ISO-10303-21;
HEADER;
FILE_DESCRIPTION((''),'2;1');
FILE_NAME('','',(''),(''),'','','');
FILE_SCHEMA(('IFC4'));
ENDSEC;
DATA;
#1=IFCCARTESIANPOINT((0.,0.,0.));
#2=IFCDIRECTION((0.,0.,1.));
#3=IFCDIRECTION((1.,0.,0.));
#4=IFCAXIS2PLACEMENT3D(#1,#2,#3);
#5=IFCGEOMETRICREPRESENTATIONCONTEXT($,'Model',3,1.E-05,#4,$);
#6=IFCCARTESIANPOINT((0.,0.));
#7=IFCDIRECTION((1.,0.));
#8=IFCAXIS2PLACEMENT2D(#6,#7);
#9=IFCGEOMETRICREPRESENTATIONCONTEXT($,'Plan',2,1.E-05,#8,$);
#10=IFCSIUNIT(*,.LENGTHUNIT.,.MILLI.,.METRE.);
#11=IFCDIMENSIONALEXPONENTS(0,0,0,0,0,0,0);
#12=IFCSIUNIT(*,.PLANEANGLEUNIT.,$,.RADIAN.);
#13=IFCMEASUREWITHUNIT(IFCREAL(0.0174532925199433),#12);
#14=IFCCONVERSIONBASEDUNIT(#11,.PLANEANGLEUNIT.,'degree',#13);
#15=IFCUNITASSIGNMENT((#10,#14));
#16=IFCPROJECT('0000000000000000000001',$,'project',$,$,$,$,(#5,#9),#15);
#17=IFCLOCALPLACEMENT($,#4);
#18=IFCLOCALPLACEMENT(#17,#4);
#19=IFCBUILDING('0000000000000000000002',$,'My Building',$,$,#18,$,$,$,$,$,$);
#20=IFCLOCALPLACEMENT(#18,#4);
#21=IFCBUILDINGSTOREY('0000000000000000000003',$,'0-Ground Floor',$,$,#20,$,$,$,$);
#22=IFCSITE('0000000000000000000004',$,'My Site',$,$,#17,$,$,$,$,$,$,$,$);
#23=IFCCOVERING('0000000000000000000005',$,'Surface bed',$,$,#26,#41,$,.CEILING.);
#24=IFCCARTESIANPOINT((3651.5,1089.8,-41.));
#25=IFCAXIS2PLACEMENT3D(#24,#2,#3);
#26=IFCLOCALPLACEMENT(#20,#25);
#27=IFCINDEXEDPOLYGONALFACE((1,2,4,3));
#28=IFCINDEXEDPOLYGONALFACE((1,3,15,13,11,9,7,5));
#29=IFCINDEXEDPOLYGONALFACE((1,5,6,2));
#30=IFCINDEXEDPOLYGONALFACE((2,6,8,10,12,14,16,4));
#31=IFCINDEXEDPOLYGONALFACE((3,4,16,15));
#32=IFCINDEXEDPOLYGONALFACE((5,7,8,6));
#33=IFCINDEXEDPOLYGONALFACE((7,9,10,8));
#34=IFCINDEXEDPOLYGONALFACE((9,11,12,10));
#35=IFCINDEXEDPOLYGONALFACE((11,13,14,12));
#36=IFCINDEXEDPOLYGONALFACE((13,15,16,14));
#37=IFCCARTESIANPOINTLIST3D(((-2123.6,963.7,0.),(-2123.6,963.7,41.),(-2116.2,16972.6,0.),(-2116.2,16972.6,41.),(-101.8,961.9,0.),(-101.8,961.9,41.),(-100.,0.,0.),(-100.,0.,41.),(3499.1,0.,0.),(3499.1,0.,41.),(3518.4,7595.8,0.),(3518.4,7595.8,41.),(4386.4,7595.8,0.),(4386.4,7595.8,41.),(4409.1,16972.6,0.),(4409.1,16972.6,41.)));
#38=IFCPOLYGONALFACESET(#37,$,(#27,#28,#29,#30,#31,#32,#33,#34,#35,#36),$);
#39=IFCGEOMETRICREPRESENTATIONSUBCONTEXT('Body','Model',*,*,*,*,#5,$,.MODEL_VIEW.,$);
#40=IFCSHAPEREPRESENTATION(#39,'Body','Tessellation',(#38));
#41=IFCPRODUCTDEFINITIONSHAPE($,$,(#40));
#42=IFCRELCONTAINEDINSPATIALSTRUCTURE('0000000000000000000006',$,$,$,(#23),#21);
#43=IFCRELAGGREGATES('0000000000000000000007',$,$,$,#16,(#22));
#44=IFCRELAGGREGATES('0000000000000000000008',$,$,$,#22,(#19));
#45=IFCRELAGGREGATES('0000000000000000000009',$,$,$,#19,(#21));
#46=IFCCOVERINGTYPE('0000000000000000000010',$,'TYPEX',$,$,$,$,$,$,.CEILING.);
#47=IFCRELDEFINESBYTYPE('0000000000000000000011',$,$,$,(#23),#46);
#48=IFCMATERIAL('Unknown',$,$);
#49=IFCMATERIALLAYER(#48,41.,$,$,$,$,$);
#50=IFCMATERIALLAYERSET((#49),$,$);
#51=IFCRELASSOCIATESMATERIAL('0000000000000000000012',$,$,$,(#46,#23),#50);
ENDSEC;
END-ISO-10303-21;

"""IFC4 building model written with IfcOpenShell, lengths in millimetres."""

from ifc_helpers import new_model, entity, si_unit, converted_unit, frame, origin_with_axes, origin_2d_with_axis, place, context, subcontext, project, spatial, line, indexed_curve, outline, extrude, material, layer, layer_set, layer_usage, type_object, element, save


model = new_model("IFC4")

# Units and contexts
model_context = context("Model", 3, precision=1e-05, world=origin_with_axes())
plan_context = context("Plan", 2, precision=1e-05, world=origin_2d_with_axis())
body_context_1 = subcontext(model_context, "Body", "Model", "MODEL_VIEW")
ifc_project = project(units=[si_unit("LENGTHUNIT", "METRE", prefix="MILLI"), converted_unit("PLANEANGLEUNIT", "degree", entity("IfcReal", 0.0174532925199433), si_unit("PLANEANGLEUNIT", "RADIAN"), dimensions=[0, 0, 0, 0, 0, 0, 0])], contexts=[model_context, plan_context])

# Site, building, storey
site_placement = place(None, origin_with_axes())
site = spatial("IfcSite", under=ifc_project, at=site_placement, Name="My Site")
building_placement = place(site_placement, origin_with_axes())
building = spatial("IfcBuilding", under=site, at=building_placement, Name="My Building")
storey_placement = place(building_placement, origin_with_axes())
storey = spatial("IfcBuildingStorey", under=building, at=storey_placement, Name="0-Ground Floor")

# Shared definitions
ifc_material_1 = material(Name="Unknown")

# Covering
ifc_layer_1 = layer(ifc_material_1, 41.0)
ifc_layer_set_1 = layer_set([ifc_layer_1])
ifc_layer_usage_1 = layer_usage(ifc_layer_set_1, "AXIS3", "POSITIVE", 0.0)
covering_type = type_object("IfcCoveringType", Name="TYPEX", PredefinedType="CEILING", material=ifc_layer_set_1)
covering_placement = place(storey_placement, frame((3651.5, 1089.8, -41.0), z_axis=(0.0, 0.0, 1.0), x_axis=(1.0, 0.0, 0.0)))
element("IfcCovering", 1, at=covering_placement, inside=storey, type_object=covering_type, material=ifc_layer_usage_1, Name="Surface bed", PredefinedType="CEILING", context=body_context_1, shape_type="SweptSolid", body=[
    extrude(outline(indexed_curve([(4386.4, 7595.8), (4409.1, 16972.6), (-2116.2, 16972.6), (-2123.6, 963.7), (-101.8, 961.9), (-100.0, 0.0), (3499.1, 0.0), (3518.4, 7595.8)], segments=[line(3, 2), line(2, 1), line(1, 8), line(8, 7), line(7, 6), line(6, 5), line(5, 4), line(4, 3)], self_intersect=False)), None, (0.0, 0.0, 1.0), 41.0),
])

save(model, "model.ifc")
